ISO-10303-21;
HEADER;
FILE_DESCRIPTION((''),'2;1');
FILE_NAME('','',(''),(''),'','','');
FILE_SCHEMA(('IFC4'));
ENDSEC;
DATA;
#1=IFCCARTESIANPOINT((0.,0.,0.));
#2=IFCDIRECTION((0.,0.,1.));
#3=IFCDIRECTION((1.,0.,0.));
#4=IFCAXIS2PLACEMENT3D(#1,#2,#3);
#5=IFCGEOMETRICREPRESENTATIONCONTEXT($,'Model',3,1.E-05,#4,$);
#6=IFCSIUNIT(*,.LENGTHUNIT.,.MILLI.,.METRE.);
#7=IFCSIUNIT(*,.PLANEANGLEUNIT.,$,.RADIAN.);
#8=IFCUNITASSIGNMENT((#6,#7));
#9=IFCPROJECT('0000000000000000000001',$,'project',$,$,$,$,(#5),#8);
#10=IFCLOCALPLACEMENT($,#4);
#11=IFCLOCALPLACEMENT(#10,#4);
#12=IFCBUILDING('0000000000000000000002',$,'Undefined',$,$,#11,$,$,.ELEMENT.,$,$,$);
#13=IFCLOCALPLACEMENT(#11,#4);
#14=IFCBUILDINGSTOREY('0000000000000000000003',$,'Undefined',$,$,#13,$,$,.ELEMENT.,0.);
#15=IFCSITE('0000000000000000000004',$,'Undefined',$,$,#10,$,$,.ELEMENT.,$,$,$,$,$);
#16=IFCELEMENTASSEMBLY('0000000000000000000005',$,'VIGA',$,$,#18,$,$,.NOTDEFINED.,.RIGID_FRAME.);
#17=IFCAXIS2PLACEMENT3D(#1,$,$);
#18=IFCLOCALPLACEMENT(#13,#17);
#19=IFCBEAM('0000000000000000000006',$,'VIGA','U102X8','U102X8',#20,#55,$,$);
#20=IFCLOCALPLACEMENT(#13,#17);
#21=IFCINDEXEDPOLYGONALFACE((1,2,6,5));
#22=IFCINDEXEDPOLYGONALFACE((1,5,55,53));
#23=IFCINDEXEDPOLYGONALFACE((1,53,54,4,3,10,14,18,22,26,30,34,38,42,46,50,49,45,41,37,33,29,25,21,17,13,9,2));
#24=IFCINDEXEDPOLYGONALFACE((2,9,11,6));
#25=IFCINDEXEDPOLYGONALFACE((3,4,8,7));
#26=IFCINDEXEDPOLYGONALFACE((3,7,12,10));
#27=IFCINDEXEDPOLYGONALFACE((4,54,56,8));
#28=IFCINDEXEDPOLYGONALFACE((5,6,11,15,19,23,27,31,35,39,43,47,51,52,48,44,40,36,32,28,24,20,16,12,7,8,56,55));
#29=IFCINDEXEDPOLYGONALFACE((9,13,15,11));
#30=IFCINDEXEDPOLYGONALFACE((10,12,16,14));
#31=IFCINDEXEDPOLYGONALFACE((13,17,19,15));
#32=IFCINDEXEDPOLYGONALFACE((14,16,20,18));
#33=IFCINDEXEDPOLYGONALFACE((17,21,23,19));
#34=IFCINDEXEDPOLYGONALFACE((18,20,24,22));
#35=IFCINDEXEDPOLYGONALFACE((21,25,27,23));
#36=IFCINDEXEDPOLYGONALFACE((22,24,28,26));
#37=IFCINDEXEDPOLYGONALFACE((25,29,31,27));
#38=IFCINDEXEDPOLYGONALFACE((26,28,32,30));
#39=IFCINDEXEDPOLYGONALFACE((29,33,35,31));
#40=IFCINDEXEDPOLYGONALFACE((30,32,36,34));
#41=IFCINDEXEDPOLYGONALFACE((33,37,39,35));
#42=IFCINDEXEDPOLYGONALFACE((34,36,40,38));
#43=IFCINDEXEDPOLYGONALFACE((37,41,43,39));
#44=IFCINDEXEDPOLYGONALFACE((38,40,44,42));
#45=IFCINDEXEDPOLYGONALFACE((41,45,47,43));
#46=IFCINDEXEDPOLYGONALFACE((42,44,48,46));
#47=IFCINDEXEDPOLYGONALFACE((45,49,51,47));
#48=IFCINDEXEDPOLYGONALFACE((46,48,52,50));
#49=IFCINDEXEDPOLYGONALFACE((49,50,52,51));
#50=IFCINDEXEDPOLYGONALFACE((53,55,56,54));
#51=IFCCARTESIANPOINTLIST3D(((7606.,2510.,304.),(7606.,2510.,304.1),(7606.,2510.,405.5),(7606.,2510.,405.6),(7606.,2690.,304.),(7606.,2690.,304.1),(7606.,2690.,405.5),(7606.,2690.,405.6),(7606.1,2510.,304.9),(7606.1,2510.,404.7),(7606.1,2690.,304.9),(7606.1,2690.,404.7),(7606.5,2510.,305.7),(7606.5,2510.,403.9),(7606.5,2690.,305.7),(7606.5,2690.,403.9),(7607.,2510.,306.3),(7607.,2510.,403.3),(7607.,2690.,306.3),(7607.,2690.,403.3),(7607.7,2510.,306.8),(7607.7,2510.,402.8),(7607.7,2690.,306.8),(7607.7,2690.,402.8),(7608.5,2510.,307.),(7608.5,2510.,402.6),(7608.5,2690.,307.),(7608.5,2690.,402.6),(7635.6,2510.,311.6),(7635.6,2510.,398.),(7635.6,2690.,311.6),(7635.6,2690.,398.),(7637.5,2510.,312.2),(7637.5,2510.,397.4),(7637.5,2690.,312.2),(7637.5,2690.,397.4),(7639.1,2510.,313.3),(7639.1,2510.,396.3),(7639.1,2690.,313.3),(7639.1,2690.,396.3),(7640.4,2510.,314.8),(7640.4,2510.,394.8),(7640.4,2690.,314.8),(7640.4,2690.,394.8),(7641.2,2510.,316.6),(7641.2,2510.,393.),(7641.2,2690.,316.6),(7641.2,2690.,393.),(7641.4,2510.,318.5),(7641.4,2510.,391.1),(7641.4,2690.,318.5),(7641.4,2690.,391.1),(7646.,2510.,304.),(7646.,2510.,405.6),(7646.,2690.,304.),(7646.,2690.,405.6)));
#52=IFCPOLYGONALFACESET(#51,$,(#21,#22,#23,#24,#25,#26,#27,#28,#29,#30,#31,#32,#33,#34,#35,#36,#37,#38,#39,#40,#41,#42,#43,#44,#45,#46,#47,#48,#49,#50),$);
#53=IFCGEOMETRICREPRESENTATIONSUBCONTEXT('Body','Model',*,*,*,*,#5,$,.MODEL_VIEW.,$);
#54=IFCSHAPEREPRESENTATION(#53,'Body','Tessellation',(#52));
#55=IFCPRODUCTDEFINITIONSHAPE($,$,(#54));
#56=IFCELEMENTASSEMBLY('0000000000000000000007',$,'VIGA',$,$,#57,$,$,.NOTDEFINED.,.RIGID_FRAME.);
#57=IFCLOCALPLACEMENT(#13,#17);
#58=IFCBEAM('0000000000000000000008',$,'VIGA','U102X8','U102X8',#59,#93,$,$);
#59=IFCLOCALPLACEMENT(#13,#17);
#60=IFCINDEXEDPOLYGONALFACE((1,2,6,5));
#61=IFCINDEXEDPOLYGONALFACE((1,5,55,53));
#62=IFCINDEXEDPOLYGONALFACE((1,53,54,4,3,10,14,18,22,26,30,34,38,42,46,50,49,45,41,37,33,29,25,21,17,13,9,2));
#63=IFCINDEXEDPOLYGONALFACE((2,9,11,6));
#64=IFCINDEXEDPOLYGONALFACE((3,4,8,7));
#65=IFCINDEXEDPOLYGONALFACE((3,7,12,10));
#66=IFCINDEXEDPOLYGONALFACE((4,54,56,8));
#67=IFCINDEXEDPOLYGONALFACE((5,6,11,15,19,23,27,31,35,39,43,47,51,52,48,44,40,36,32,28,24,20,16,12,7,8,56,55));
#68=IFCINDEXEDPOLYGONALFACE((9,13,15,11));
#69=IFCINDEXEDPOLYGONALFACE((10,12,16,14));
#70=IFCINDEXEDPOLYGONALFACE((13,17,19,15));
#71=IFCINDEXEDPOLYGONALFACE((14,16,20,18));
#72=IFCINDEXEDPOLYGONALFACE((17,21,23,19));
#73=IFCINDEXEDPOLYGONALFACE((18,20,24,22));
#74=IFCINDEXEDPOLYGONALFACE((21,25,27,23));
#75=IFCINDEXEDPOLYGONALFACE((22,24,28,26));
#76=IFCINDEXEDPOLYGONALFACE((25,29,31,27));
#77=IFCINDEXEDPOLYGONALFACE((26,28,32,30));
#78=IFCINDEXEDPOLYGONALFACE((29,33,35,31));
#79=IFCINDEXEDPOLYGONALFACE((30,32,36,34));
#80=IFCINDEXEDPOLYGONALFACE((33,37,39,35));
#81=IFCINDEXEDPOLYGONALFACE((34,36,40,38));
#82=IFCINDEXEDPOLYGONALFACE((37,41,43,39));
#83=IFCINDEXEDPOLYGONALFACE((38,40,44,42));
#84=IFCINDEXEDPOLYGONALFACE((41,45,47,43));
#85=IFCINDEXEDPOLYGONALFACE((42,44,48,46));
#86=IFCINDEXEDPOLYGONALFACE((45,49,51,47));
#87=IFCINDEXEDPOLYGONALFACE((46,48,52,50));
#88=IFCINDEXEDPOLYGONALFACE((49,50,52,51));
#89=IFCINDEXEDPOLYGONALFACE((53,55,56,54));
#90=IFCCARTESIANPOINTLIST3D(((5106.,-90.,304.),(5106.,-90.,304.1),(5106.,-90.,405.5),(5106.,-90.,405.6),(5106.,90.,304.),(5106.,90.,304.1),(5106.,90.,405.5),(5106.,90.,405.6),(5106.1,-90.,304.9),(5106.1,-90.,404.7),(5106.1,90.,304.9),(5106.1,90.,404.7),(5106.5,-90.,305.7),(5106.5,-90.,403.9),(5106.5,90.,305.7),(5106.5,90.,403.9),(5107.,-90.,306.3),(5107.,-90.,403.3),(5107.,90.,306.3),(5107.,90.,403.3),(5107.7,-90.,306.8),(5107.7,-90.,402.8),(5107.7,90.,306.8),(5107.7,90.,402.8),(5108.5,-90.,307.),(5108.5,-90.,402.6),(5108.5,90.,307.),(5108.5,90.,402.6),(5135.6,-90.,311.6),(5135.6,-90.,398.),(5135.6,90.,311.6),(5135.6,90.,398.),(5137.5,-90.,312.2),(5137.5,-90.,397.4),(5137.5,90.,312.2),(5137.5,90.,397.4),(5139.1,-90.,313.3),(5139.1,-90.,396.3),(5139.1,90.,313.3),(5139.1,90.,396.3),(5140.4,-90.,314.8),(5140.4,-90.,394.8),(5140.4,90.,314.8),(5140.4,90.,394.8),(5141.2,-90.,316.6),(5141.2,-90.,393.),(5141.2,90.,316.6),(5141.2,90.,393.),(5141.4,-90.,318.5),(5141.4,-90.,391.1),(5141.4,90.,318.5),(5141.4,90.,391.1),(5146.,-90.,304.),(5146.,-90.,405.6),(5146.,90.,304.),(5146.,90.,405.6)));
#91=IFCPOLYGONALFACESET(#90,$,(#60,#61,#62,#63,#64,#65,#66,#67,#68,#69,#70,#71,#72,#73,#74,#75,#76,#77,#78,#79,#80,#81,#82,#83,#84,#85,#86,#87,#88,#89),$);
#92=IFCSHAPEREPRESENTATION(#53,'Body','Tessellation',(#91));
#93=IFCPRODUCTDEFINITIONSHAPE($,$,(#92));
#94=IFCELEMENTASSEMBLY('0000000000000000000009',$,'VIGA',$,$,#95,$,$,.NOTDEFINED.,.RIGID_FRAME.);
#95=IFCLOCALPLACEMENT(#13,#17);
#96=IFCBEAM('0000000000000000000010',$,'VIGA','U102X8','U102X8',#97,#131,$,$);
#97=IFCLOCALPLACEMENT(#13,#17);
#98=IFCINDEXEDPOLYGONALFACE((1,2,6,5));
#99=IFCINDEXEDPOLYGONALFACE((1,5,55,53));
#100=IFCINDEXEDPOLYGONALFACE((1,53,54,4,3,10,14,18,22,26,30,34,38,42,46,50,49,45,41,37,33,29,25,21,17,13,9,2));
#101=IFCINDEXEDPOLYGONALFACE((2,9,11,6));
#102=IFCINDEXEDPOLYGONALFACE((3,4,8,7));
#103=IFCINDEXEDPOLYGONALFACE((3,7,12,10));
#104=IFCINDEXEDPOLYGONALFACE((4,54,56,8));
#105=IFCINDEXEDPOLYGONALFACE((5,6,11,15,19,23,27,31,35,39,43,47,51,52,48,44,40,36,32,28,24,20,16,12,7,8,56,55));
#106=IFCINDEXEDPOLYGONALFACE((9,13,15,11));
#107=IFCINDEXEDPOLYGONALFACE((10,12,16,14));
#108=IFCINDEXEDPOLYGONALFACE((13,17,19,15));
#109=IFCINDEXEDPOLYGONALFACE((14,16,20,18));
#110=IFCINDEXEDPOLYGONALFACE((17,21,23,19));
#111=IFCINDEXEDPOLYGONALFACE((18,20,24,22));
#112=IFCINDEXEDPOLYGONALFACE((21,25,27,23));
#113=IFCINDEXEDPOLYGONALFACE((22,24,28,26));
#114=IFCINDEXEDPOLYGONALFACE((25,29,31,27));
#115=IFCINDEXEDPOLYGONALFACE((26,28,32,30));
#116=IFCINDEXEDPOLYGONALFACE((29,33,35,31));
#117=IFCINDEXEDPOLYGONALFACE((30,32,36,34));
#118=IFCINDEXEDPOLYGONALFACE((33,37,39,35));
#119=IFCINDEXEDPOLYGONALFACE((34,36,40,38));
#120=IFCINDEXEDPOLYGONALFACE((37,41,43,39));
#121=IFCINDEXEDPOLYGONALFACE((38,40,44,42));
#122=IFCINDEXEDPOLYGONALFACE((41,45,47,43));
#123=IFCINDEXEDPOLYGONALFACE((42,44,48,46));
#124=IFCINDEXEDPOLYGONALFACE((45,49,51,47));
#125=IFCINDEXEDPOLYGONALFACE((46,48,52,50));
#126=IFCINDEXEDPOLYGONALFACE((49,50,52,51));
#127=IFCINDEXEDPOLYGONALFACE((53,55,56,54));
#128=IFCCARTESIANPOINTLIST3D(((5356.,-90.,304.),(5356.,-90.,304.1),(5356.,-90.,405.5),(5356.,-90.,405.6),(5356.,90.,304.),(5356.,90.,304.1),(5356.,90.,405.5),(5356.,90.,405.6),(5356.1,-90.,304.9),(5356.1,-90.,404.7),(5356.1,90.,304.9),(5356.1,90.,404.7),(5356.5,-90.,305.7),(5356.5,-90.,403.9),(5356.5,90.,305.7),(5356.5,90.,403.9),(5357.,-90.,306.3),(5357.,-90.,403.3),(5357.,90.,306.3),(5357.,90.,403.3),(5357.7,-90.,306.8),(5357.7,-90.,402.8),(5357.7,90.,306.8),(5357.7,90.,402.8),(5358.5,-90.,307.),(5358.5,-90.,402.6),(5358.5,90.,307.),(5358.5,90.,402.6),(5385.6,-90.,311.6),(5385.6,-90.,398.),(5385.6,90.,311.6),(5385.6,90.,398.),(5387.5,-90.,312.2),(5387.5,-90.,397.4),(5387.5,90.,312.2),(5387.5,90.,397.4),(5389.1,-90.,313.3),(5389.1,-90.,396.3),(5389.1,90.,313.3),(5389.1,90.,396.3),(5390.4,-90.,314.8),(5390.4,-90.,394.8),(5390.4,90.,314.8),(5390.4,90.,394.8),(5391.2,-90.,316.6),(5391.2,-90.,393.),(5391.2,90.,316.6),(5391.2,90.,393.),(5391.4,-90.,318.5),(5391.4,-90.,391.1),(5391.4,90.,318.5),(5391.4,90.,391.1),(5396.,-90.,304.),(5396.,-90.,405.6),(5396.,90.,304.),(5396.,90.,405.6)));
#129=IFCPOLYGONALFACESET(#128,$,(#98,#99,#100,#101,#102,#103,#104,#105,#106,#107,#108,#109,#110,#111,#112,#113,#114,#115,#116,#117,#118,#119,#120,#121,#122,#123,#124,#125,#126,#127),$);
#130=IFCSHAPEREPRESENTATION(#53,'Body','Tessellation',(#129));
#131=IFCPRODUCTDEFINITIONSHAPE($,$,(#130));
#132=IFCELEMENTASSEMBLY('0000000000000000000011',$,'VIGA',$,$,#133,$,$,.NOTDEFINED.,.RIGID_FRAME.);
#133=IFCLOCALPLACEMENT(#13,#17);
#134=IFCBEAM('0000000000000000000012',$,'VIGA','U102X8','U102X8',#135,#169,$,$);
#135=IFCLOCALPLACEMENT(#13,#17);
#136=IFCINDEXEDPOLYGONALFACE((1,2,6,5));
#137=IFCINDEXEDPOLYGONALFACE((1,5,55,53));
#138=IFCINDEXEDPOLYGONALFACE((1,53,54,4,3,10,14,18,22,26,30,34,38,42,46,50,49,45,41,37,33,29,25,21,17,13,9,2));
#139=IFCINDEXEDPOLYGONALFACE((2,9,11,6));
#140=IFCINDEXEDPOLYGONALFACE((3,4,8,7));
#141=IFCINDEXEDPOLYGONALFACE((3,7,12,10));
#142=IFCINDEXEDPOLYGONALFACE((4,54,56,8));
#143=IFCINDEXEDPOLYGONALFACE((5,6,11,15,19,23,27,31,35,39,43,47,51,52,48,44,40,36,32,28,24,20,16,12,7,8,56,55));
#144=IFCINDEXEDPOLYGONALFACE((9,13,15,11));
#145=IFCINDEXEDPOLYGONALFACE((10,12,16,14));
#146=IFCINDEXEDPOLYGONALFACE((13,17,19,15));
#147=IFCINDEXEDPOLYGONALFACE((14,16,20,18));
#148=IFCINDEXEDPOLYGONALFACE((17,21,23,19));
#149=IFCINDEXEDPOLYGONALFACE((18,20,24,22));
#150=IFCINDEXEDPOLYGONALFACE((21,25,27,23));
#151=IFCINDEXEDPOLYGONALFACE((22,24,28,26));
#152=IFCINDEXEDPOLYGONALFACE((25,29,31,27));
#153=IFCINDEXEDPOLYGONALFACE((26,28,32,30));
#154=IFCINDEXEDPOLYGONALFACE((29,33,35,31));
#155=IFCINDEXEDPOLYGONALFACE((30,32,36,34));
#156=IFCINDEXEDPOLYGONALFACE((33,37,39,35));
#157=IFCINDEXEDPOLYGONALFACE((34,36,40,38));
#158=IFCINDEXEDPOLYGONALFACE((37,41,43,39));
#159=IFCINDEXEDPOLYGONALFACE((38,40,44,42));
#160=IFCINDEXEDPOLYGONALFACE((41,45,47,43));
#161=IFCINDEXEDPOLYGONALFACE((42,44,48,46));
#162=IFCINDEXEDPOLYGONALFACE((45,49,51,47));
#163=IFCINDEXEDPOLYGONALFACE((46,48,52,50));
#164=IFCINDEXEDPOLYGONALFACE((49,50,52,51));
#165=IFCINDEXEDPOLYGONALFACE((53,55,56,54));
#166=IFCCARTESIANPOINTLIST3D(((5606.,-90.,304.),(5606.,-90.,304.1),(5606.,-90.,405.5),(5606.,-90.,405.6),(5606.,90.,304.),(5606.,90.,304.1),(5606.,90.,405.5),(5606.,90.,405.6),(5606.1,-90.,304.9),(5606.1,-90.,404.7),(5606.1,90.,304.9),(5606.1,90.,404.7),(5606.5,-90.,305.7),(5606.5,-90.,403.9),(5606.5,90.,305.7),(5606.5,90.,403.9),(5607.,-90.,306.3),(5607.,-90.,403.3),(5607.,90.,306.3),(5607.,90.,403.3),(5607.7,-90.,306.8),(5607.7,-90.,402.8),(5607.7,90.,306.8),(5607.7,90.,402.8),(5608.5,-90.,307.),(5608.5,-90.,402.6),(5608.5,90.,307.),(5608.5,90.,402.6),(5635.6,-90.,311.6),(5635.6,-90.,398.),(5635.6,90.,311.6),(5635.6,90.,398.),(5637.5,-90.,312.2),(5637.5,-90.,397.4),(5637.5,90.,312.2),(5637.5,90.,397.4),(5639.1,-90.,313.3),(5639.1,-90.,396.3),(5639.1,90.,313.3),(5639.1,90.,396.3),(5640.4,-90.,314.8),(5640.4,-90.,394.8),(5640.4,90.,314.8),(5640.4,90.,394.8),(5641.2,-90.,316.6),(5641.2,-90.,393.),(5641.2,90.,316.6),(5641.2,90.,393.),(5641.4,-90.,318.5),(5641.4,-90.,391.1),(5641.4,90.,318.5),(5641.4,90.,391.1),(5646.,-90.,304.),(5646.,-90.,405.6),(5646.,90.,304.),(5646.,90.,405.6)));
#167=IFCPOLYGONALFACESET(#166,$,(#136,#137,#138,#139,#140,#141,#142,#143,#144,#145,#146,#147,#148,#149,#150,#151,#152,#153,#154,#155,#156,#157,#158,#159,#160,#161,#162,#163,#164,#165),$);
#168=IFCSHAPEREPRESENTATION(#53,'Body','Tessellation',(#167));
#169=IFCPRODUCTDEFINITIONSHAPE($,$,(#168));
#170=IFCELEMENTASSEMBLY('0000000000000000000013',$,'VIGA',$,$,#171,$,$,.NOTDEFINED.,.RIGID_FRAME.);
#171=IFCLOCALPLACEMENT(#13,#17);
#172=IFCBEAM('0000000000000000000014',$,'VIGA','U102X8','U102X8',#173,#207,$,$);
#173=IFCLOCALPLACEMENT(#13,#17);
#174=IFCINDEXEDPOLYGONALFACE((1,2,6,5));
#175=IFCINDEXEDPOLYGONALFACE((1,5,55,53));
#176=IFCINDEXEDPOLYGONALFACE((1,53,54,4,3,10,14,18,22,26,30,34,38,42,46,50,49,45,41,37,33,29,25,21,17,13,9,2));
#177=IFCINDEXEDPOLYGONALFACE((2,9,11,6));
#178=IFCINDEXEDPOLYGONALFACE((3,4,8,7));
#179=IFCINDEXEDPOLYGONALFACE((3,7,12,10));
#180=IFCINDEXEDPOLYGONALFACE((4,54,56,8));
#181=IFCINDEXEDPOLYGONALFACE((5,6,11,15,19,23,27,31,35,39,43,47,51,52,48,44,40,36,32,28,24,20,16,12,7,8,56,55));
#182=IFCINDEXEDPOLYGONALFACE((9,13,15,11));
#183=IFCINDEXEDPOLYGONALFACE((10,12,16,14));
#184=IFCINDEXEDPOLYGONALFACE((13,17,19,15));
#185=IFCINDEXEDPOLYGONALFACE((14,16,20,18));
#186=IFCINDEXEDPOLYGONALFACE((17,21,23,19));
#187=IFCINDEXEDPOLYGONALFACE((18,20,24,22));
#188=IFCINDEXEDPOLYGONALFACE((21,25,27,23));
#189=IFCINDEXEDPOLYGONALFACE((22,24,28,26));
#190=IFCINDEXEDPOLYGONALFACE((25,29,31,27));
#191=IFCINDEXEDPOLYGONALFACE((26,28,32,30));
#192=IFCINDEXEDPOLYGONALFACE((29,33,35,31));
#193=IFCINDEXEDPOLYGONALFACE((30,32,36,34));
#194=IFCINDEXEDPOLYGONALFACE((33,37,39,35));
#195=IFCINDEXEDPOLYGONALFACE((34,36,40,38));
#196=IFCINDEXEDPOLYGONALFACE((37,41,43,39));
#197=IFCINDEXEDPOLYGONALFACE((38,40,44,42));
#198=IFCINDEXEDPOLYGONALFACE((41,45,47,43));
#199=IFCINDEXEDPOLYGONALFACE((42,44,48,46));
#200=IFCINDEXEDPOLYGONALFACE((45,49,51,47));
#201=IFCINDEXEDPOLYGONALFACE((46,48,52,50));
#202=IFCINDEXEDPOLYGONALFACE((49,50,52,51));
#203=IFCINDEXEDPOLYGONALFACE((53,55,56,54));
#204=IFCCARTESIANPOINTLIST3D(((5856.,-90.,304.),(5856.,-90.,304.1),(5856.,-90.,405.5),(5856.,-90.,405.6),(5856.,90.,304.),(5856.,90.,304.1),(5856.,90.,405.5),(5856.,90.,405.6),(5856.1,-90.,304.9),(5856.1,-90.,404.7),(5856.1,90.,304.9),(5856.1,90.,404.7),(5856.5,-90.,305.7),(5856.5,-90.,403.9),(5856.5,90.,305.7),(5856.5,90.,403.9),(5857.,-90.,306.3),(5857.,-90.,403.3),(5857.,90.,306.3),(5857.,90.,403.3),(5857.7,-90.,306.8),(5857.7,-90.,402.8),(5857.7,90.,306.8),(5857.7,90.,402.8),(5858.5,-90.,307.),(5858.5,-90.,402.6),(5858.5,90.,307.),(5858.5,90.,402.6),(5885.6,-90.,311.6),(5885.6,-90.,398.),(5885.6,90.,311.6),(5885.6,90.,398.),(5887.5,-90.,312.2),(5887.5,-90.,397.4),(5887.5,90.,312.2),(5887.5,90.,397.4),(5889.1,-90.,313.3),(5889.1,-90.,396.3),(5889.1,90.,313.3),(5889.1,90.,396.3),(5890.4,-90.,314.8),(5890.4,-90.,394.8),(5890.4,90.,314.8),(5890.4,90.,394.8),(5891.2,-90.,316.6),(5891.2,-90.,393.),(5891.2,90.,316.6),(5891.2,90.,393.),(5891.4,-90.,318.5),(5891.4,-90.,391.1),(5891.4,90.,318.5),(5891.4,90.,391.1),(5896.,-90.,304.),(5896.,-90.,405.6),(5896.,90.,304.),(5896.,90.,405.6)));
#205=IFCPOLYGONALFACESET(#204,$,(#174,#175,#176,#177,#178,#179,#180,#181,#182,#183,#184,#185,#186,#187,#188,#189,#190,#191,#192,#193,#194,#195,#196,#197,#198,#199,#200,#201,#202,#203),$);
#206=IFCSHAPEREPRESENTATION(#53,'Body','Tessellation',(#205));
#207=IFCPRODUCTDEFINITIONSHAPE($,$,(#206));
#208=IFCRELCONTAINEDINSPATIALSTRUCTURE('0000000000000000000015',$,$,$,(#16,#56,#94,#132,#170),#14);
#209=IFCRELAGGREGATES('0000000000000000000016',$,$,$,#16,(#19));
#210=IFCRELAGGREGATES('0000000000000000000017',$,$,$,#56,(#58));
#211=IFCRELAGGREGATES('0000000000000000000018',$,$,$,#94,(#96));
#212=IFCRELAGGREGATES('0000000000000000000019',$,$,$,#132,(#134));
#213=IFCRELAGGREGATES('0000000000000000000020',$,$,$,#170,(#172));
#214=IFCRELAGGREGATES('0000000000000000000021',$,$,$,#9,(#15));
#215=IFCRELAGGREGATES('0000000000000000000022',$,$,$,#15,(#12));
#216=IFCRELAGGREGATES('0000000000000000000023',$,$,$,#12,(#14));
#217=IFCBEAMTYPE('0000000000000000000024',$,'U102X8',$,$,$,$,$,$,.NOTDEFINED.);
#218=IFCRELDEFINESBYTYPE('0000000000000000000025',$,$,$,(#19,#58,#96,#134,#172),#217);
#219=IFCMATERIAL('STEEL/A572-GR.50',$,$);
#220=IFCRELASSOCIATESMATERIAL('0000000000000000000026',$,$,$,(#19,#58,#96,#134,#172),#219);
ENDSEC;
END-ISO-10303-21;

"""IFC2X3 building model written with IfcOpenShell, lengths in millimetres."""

from ifc_helpers import new_model, si_unit, frame, origin_with_axes, origin_2d_with_axis, place, context, subcontext, project, spatial, u_section, extrude, material, type_object, element, aggregate, save


model = new_model("IFC2X3")

# Units and contexts
model_context = context("Model", 3, precision=1e-05, world=origin_with_axes())
body_context = subcontext(model_context, "Body", "Model", "MODEL_VIEW")
ifc_project = project(units=[si_unit("LENGTHUNIT", "METRE", prefix="MILLI"), si_unit("PLANEANGLEUNIT", "RADIAN")], contexts=[model_context])

# Site, building, storey
site_placement = place(None, origin_with_axes())
site = spatial("IfcSite", under=ifc_project, at=site_placement, Name="Undefined", CompositionType="ELEMENT")
building_placement = place(site_placement, origin_with_axes())
building = spatial("IfcBuilding", under=site, at=building_placement, Name="Undefined", CompositionType="ELEMENT")
storey_placement = place(building_placement, origin_with_axes())
storey = spatial("IfcBuildingStorey", under=building, at=storey_placement, Name="Undefined", CompositionType="ELEMENT", Elevation=0.0)

# Element assemblies, beams
ifc_material_1 = material(Name="STEEL/A572-GR.50")
beam_type_1 = type_object("IfcBeamType", Name="U102X8", PredefinedType="NOTDEFINED")
assembly_1_placement = place(storey_placement, origin_with_axes())
assembly_1 = element("IfcElementAssembly", 1, at=assembly_1_placement, inside=storey, Name="VIGA", AssemblyPlace="NOTDEFINED", PredefinedType="RIGID_FRAME")
beam_1_placement = place(assembly_1_placement, frame((7626.0, 2690.0, 354.8), z_axis=(0.0, 0.0, 1.0), x_axis=(0.0, -1.0, 0.0)))
beam_1 = element("IfcBeam", 2, at=beam_1_placement, type_object=beam_type_1, material=ifc_material_1, Name="VIGA", Description="U102X8", ObjectType="U102X8", context=body_context, shape_type="SweptSolid", body=[
    extrude(u_section(Depth=101.6, FlangeWidth=40.0, WebThickness=4.6, FlangeThickness=6.0, FilletRadius=7.0, EdgeRadius=3.0, FlangeSlope=0.16839, at=origin_2d_with_axis()), frame((180.0, 0.0, 0.0), z_axis=(-1.0, 0.0, 0.0), x_axis=(0.0, -1.0, 0.0)), (0.0, 0.0, 1.0), 180.0),
])
aggregate(assembly_1, [beam_1])
assembly_2_placement = place(storey_placement, origin_with_axes())
assembly_2 = element("IfcElementAssembly", 3, at=assembly_2_placement, inside=storey, Name="VIGA", AssemblyPlace="NOTDEFINED", PredefinedType="RIGID_FRAME")
beam_2_placement = place(assembly_2_placement, frame((5126.0, 90.0, 354.8), z_axis=(0.0, 0.0, 1.0), x_axis=(0.0, -1.0, 0.0)))
beam_2 = element("IfcBeam", 4, at=beam_2_placement, type_object=beam_type_1, material=ifc_material_1, Name="VIGA", Description="U102X8", ObjectType="U102X8", context=body_context, shape_type="SweptSolid", body=[
    extrude(u_section(Depth=101.6, FlangeWidth=40.0, WebThickness=4.6, FlangeThickness=6.0, FilletRadius=7.0, EdgeRadius=3.0, FlangeSlope=0.16839, at=origin_2d_with_axis()), frame((180.0, 0.0, 0.0), z_axis=(-1.0, 0.0, 0.0), x_axis=(0.0, -1.0, 0.0)), (0.0, 0.0, 1.0), 180.0),
])
aggregate(assembly_2, [beam_2])
assembly_3_placement = place(storey_placement, origin_with_axes())
assembly_3 = element("IfcElementAssembly", 5, at=assembly_3_placement, inside=storey, Name="VIGA", AssemblyPlace="NOTDEFINED", PredefinedType="RIGID_FRAME")
beam_3_placement = place(assembly_3_placement, frame((5376.0, 90.0, 354.8), z_axis=(0.0, 0.0, 1.0), x_axis=(0.0, -1.0, 0.0)))
beam_3 = element("IfcBeam", 6, at=beam_3_placement, type_object=beam_type_1, material=ifc_material_1, Name="VIGA", Description="U102X8", ObjectType="U102X8", context=body_context, shape_type="SweptSolid", body=[
    extrude(u_section(Depth=101.6, FlangeWidth=40.0, WebThickness=4.6, FlangeThickness=6.0, FilletRadius=7.0, EdgeRadius=3.0, FlangeSlope=0.16839, at=origin_2d_with_axis()), frame((180.0, 0.0, 0.0), z_axis=(-1.0, 0.0, 0.0), x_axis=(0.0, -1.0, 0.0)), (0.0, 0.0, 1.0), 180.0),
])
aggregate(assembly_3, [beam_3])
assembly_4_placement = place(storey_placement, origin_with_axes())
assembly_4 = element("IfcElementAssembly", 7, at=assembly_4_placement, inside=storey, Name="VIGA", AssemblyPlace="NOTDEFINED", PredefinedType="RIGID_FRAME")
beam_4_placement = place(assembly_4_placement, frame((5626.0, 90.0, 354.8), z_axis=(0.0, 0.0, 1.0), x_axis=(0.0, -1.0, 0.0)))
beam_4 = element("IfcBeam", 8, at=beam_4_placement, type_object=beam_type_1, material=ifc_material_1, Name="VIGA", Description="U102X8", ObjectType="U102X8", context=body_context, shape_type="SweptSolid", body=[
    extrude(u_section(Depth=101.6, FlangeWidth=40.0, WebThickness=4.6, FlangeThickness=6.0, FilletRadius=7.0, EdgeRadius=3.0, FlangeSlope=0.16839, at=origin_2d_with_axis()), frame((180.0, 0.0, 0.0), z_axis=(-1.0, 0.0, 0.0), x_axis=(0.0, -1.0, 0.0)), (0.0, 0.0, 1.0), 180.0),
])
aggregate(assembly_4, [beam_4])
assembly_5_placement = place(storey_placement, origin_with_axes())
assembly_5 = element("IfcElementAssembly", 9, at=assembly_5_placement, inside=storey, Name="VIGA", AssemblyPlace="NOTDEFINED", PredefinedType="RIGID_FRAME")
beam_5_placement = place(assembly_5_placement, frame((5876.0, 90.0, 354.8), z_axis=(0.0, 0.0, 1.0), x_axis=(0.0, -1.0, 0.0)))
beam_5 = element("IfcBeam", 10, at=beam_5_placement, type_object=beam_type_1, material=ifc_material_1, Name="VIGA", Description="U102X8", ObjectType="U102X8", context=body_context, shape_type="SweptSolid", body=[
    extrude(u_section(Depth=101.6, FlangeWidth=40.0, WebThickness=4.6, FlangeThickness=6.0, FilletRadius=7.0, EdgeRadius=3.0, FlangeSlope=0.16839, at=origin_2d_with_axis()), frame((180.0, 0.0, 0.0), z_axis=(-1.0, 0.0, 0.0), x_axis=(0.0, -1.0, 0.0)), (0.0, 0.0, 1.0), 180.0),
])
aggregate(assembly_5, [beam_5])

save(model, "model.ifc")
